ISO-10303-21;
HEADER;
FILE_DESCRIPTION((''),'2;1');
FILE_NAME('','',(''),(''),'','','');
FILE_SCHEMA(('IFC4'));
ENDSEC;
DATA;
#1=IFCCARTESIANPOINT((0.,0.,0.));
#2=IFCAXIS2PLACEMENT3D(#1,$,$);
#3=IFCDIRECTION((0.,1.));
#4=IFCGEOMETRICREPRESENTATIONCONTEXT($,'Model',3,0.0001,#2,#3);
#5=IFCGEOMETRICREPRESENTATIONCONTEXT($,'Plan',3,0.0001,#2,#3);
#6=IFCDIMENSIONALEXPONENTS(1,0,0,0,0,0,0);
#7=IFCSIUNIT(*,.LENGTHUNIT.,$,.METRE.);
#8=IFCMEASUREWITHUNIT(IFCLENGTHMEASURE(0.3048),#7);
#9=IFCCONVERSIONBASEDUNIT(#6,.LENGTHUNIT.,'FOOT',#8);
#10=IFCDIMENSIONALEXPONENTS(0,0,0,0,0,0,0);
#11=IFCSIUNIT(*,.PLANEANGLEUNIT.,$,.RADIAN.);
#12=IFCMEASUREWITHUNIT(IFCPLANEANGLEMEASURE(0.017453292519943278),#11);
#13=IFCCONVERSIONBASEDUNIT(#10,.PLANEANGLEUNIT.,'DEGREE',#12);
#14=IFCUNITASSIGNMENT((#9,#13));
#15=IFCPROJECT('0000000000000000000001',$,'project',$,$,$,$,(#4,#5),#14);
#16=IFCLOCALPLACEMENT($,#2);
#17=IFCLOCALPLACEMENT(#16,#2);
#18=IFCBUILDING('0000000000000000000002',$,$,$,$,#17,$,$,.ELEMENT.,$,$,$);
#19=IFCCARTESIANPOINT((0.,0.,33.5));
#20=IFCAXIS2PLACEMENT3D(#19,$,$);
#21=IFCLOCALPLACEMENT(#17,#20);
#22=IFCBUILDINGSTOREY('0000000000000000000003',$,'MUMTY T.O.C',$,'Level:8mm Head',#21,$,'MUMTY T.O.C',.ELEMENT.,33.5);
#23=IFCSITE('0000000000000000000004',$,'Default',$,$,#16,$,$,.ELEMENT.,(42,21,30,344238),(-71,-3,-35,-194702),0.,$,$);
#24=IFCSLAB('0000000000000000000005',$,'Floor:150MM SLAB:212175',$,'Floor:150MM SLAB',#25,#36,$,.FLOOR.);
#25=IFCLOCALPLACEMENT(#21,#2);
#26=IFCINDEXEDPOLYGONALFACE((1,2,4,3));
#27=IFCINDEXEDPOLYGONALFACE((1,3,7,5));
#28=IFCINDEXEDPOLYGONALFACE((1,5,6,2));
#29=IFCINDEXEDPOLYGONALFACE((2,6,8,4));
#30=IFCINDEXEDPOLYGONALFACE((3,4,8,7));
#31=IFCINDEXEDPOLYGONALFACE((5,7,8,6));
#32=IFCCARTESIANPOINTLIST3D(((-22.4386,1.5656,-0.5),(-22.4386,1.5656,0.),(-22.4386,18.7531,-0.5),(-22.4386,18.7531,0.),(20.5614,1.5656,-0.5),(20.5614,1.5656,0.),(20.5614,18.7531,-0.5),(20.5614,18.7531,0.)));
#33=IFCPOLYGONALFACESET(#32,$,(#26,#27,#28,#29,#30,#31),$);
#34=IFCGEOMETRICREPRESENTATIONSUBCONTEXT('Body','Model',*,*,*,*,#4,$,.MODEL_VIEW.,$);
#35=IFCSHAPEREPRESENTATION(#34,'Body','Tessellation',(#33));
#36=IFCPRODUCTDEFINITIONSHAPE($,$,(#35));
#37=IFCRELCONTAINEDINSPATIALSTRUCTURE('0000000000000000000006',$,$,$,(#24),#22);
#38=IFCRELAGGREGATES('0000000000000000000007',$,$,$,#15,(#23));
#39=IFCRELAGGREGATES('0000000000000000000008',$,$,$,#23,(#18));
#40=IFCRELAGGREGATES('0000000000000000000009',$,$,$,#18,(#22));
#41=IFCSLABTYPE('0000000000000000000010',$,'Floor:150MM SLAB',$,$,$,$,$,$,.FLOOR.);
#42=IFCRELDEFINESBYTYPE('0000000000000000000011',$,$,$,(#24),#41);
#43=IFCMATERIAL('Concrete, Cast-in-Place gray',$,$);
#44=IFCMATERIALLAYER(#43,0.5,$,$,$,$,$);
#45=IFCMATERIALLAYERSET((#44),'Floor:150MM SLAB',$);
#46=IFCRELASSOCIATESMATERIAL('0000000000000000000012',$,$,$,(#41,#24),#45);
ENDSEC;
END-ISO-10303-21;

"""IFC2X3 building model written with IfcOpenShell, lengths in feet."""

from ifc_helpers import new_model, entity, si_unit, converted_unit, direction, frame, frame_2d, origin, place, context, subcontext, project, spatial, rectangle, extrude, material, layer, layer_set, layer_usage, type_object, element, save


model = new_model("IFC2X3")

# Units and contexts
model_context = context("Model", 3, precision=0.0001, world=origin(), true_north=direction((0.0, 1.0)))
plan_context = context("Plan", 3, precision=0.0001, world=origin(), true_north=direction((0.0, 1.0)))
body_context = subcontext(model_context, "Body", "Model", "MODEL_VIEW")
ifc_project = project(units=[converted_unit("LENGTHUNIT", "FOOT", entity("IfcLengthMeasure", 0.3048), si_unit("LENGTHUNIT", "METRE"), dimensions=[1, 0, 0, 0, 0, 0, 0]), converted_unit("PLANEANGLEUNIT", "DEGREE", entity("IfcPlaneAngleMeasure", 0.017453292519943278), si_unit("PLANEANGLEUNIT", "RADIAN"), dimensions=[0, 0, 0, 0, 0, 0, 0])], contexts=[model_context, plan_context])

# Site, building, storey
site_placement = place(None, origin())
site = spatial("IfcSite", under=ifc_project, at=site_placement, Name="Default", CompositionType="ELEMENT", RefLatitude=(42, 21, 30, 344238), RefLongitude=(-71, -3, -35, -194702), RefElevation=0.0)
building_placement = place(site_placement, origin())
building = spatial("IfcBuilding", under=site, at=building_placement, CompositionType="ELEMENT")
storey_placement = place(building_placement, frame((0.0, 0.0, 33.5)))
storey = spatial("IfcBuildingStorey", under=building, at=storey_placement, Name="MUMTY T.O.C", ObjectType="Level:8mm Head", LongName="MUMTY T.O.C", CompositionType="ELEMENT", Elevation=33.5)

# Slab
ifc_material = material(Name="Concrete, Cast-in-Place gray")
ifc_layer = layer(ifc_material, 0.5)
ifc_layer_set = layer_set([ifc_layer], Name="Floor:150MM SLAB")
ifc_layer_usage = layer_usage(ifc_layer_set, "AXIS3", "POSITIVE", 0.0)
slab_type = type_object("IfcSlabType", Name="Floor:150MM SLAB", PredefinedType="FLOOR", material=ifc_layer_set)
slab_placement = place(storey_placement, origin())
element("IfcSlab", 1, at=slab_placement, inside=storey, type_object=slab_type, material=ifc_layer_usage, Name="Floor:150MM SLAB:212175", ObjectType="Floor:150MM SLAB", PredefinedType="FLOOR", context=body_context, shape_type="SweptSolid", body=[
    extrude(rectangle(XDim=17.1875, YDim=43.0, at=frame_2d((0.0, 0.0), x_axis=(1.0, 0.0))), frame((-0.9386, 10.1594, 0.0), z_axis=(0.0, 0.0, -1.0), x_axis=(0.0, 1.0, 0.0)), (0.0, 0.0, 1.0), 0.5),
])

save(model, "model.ifc")
